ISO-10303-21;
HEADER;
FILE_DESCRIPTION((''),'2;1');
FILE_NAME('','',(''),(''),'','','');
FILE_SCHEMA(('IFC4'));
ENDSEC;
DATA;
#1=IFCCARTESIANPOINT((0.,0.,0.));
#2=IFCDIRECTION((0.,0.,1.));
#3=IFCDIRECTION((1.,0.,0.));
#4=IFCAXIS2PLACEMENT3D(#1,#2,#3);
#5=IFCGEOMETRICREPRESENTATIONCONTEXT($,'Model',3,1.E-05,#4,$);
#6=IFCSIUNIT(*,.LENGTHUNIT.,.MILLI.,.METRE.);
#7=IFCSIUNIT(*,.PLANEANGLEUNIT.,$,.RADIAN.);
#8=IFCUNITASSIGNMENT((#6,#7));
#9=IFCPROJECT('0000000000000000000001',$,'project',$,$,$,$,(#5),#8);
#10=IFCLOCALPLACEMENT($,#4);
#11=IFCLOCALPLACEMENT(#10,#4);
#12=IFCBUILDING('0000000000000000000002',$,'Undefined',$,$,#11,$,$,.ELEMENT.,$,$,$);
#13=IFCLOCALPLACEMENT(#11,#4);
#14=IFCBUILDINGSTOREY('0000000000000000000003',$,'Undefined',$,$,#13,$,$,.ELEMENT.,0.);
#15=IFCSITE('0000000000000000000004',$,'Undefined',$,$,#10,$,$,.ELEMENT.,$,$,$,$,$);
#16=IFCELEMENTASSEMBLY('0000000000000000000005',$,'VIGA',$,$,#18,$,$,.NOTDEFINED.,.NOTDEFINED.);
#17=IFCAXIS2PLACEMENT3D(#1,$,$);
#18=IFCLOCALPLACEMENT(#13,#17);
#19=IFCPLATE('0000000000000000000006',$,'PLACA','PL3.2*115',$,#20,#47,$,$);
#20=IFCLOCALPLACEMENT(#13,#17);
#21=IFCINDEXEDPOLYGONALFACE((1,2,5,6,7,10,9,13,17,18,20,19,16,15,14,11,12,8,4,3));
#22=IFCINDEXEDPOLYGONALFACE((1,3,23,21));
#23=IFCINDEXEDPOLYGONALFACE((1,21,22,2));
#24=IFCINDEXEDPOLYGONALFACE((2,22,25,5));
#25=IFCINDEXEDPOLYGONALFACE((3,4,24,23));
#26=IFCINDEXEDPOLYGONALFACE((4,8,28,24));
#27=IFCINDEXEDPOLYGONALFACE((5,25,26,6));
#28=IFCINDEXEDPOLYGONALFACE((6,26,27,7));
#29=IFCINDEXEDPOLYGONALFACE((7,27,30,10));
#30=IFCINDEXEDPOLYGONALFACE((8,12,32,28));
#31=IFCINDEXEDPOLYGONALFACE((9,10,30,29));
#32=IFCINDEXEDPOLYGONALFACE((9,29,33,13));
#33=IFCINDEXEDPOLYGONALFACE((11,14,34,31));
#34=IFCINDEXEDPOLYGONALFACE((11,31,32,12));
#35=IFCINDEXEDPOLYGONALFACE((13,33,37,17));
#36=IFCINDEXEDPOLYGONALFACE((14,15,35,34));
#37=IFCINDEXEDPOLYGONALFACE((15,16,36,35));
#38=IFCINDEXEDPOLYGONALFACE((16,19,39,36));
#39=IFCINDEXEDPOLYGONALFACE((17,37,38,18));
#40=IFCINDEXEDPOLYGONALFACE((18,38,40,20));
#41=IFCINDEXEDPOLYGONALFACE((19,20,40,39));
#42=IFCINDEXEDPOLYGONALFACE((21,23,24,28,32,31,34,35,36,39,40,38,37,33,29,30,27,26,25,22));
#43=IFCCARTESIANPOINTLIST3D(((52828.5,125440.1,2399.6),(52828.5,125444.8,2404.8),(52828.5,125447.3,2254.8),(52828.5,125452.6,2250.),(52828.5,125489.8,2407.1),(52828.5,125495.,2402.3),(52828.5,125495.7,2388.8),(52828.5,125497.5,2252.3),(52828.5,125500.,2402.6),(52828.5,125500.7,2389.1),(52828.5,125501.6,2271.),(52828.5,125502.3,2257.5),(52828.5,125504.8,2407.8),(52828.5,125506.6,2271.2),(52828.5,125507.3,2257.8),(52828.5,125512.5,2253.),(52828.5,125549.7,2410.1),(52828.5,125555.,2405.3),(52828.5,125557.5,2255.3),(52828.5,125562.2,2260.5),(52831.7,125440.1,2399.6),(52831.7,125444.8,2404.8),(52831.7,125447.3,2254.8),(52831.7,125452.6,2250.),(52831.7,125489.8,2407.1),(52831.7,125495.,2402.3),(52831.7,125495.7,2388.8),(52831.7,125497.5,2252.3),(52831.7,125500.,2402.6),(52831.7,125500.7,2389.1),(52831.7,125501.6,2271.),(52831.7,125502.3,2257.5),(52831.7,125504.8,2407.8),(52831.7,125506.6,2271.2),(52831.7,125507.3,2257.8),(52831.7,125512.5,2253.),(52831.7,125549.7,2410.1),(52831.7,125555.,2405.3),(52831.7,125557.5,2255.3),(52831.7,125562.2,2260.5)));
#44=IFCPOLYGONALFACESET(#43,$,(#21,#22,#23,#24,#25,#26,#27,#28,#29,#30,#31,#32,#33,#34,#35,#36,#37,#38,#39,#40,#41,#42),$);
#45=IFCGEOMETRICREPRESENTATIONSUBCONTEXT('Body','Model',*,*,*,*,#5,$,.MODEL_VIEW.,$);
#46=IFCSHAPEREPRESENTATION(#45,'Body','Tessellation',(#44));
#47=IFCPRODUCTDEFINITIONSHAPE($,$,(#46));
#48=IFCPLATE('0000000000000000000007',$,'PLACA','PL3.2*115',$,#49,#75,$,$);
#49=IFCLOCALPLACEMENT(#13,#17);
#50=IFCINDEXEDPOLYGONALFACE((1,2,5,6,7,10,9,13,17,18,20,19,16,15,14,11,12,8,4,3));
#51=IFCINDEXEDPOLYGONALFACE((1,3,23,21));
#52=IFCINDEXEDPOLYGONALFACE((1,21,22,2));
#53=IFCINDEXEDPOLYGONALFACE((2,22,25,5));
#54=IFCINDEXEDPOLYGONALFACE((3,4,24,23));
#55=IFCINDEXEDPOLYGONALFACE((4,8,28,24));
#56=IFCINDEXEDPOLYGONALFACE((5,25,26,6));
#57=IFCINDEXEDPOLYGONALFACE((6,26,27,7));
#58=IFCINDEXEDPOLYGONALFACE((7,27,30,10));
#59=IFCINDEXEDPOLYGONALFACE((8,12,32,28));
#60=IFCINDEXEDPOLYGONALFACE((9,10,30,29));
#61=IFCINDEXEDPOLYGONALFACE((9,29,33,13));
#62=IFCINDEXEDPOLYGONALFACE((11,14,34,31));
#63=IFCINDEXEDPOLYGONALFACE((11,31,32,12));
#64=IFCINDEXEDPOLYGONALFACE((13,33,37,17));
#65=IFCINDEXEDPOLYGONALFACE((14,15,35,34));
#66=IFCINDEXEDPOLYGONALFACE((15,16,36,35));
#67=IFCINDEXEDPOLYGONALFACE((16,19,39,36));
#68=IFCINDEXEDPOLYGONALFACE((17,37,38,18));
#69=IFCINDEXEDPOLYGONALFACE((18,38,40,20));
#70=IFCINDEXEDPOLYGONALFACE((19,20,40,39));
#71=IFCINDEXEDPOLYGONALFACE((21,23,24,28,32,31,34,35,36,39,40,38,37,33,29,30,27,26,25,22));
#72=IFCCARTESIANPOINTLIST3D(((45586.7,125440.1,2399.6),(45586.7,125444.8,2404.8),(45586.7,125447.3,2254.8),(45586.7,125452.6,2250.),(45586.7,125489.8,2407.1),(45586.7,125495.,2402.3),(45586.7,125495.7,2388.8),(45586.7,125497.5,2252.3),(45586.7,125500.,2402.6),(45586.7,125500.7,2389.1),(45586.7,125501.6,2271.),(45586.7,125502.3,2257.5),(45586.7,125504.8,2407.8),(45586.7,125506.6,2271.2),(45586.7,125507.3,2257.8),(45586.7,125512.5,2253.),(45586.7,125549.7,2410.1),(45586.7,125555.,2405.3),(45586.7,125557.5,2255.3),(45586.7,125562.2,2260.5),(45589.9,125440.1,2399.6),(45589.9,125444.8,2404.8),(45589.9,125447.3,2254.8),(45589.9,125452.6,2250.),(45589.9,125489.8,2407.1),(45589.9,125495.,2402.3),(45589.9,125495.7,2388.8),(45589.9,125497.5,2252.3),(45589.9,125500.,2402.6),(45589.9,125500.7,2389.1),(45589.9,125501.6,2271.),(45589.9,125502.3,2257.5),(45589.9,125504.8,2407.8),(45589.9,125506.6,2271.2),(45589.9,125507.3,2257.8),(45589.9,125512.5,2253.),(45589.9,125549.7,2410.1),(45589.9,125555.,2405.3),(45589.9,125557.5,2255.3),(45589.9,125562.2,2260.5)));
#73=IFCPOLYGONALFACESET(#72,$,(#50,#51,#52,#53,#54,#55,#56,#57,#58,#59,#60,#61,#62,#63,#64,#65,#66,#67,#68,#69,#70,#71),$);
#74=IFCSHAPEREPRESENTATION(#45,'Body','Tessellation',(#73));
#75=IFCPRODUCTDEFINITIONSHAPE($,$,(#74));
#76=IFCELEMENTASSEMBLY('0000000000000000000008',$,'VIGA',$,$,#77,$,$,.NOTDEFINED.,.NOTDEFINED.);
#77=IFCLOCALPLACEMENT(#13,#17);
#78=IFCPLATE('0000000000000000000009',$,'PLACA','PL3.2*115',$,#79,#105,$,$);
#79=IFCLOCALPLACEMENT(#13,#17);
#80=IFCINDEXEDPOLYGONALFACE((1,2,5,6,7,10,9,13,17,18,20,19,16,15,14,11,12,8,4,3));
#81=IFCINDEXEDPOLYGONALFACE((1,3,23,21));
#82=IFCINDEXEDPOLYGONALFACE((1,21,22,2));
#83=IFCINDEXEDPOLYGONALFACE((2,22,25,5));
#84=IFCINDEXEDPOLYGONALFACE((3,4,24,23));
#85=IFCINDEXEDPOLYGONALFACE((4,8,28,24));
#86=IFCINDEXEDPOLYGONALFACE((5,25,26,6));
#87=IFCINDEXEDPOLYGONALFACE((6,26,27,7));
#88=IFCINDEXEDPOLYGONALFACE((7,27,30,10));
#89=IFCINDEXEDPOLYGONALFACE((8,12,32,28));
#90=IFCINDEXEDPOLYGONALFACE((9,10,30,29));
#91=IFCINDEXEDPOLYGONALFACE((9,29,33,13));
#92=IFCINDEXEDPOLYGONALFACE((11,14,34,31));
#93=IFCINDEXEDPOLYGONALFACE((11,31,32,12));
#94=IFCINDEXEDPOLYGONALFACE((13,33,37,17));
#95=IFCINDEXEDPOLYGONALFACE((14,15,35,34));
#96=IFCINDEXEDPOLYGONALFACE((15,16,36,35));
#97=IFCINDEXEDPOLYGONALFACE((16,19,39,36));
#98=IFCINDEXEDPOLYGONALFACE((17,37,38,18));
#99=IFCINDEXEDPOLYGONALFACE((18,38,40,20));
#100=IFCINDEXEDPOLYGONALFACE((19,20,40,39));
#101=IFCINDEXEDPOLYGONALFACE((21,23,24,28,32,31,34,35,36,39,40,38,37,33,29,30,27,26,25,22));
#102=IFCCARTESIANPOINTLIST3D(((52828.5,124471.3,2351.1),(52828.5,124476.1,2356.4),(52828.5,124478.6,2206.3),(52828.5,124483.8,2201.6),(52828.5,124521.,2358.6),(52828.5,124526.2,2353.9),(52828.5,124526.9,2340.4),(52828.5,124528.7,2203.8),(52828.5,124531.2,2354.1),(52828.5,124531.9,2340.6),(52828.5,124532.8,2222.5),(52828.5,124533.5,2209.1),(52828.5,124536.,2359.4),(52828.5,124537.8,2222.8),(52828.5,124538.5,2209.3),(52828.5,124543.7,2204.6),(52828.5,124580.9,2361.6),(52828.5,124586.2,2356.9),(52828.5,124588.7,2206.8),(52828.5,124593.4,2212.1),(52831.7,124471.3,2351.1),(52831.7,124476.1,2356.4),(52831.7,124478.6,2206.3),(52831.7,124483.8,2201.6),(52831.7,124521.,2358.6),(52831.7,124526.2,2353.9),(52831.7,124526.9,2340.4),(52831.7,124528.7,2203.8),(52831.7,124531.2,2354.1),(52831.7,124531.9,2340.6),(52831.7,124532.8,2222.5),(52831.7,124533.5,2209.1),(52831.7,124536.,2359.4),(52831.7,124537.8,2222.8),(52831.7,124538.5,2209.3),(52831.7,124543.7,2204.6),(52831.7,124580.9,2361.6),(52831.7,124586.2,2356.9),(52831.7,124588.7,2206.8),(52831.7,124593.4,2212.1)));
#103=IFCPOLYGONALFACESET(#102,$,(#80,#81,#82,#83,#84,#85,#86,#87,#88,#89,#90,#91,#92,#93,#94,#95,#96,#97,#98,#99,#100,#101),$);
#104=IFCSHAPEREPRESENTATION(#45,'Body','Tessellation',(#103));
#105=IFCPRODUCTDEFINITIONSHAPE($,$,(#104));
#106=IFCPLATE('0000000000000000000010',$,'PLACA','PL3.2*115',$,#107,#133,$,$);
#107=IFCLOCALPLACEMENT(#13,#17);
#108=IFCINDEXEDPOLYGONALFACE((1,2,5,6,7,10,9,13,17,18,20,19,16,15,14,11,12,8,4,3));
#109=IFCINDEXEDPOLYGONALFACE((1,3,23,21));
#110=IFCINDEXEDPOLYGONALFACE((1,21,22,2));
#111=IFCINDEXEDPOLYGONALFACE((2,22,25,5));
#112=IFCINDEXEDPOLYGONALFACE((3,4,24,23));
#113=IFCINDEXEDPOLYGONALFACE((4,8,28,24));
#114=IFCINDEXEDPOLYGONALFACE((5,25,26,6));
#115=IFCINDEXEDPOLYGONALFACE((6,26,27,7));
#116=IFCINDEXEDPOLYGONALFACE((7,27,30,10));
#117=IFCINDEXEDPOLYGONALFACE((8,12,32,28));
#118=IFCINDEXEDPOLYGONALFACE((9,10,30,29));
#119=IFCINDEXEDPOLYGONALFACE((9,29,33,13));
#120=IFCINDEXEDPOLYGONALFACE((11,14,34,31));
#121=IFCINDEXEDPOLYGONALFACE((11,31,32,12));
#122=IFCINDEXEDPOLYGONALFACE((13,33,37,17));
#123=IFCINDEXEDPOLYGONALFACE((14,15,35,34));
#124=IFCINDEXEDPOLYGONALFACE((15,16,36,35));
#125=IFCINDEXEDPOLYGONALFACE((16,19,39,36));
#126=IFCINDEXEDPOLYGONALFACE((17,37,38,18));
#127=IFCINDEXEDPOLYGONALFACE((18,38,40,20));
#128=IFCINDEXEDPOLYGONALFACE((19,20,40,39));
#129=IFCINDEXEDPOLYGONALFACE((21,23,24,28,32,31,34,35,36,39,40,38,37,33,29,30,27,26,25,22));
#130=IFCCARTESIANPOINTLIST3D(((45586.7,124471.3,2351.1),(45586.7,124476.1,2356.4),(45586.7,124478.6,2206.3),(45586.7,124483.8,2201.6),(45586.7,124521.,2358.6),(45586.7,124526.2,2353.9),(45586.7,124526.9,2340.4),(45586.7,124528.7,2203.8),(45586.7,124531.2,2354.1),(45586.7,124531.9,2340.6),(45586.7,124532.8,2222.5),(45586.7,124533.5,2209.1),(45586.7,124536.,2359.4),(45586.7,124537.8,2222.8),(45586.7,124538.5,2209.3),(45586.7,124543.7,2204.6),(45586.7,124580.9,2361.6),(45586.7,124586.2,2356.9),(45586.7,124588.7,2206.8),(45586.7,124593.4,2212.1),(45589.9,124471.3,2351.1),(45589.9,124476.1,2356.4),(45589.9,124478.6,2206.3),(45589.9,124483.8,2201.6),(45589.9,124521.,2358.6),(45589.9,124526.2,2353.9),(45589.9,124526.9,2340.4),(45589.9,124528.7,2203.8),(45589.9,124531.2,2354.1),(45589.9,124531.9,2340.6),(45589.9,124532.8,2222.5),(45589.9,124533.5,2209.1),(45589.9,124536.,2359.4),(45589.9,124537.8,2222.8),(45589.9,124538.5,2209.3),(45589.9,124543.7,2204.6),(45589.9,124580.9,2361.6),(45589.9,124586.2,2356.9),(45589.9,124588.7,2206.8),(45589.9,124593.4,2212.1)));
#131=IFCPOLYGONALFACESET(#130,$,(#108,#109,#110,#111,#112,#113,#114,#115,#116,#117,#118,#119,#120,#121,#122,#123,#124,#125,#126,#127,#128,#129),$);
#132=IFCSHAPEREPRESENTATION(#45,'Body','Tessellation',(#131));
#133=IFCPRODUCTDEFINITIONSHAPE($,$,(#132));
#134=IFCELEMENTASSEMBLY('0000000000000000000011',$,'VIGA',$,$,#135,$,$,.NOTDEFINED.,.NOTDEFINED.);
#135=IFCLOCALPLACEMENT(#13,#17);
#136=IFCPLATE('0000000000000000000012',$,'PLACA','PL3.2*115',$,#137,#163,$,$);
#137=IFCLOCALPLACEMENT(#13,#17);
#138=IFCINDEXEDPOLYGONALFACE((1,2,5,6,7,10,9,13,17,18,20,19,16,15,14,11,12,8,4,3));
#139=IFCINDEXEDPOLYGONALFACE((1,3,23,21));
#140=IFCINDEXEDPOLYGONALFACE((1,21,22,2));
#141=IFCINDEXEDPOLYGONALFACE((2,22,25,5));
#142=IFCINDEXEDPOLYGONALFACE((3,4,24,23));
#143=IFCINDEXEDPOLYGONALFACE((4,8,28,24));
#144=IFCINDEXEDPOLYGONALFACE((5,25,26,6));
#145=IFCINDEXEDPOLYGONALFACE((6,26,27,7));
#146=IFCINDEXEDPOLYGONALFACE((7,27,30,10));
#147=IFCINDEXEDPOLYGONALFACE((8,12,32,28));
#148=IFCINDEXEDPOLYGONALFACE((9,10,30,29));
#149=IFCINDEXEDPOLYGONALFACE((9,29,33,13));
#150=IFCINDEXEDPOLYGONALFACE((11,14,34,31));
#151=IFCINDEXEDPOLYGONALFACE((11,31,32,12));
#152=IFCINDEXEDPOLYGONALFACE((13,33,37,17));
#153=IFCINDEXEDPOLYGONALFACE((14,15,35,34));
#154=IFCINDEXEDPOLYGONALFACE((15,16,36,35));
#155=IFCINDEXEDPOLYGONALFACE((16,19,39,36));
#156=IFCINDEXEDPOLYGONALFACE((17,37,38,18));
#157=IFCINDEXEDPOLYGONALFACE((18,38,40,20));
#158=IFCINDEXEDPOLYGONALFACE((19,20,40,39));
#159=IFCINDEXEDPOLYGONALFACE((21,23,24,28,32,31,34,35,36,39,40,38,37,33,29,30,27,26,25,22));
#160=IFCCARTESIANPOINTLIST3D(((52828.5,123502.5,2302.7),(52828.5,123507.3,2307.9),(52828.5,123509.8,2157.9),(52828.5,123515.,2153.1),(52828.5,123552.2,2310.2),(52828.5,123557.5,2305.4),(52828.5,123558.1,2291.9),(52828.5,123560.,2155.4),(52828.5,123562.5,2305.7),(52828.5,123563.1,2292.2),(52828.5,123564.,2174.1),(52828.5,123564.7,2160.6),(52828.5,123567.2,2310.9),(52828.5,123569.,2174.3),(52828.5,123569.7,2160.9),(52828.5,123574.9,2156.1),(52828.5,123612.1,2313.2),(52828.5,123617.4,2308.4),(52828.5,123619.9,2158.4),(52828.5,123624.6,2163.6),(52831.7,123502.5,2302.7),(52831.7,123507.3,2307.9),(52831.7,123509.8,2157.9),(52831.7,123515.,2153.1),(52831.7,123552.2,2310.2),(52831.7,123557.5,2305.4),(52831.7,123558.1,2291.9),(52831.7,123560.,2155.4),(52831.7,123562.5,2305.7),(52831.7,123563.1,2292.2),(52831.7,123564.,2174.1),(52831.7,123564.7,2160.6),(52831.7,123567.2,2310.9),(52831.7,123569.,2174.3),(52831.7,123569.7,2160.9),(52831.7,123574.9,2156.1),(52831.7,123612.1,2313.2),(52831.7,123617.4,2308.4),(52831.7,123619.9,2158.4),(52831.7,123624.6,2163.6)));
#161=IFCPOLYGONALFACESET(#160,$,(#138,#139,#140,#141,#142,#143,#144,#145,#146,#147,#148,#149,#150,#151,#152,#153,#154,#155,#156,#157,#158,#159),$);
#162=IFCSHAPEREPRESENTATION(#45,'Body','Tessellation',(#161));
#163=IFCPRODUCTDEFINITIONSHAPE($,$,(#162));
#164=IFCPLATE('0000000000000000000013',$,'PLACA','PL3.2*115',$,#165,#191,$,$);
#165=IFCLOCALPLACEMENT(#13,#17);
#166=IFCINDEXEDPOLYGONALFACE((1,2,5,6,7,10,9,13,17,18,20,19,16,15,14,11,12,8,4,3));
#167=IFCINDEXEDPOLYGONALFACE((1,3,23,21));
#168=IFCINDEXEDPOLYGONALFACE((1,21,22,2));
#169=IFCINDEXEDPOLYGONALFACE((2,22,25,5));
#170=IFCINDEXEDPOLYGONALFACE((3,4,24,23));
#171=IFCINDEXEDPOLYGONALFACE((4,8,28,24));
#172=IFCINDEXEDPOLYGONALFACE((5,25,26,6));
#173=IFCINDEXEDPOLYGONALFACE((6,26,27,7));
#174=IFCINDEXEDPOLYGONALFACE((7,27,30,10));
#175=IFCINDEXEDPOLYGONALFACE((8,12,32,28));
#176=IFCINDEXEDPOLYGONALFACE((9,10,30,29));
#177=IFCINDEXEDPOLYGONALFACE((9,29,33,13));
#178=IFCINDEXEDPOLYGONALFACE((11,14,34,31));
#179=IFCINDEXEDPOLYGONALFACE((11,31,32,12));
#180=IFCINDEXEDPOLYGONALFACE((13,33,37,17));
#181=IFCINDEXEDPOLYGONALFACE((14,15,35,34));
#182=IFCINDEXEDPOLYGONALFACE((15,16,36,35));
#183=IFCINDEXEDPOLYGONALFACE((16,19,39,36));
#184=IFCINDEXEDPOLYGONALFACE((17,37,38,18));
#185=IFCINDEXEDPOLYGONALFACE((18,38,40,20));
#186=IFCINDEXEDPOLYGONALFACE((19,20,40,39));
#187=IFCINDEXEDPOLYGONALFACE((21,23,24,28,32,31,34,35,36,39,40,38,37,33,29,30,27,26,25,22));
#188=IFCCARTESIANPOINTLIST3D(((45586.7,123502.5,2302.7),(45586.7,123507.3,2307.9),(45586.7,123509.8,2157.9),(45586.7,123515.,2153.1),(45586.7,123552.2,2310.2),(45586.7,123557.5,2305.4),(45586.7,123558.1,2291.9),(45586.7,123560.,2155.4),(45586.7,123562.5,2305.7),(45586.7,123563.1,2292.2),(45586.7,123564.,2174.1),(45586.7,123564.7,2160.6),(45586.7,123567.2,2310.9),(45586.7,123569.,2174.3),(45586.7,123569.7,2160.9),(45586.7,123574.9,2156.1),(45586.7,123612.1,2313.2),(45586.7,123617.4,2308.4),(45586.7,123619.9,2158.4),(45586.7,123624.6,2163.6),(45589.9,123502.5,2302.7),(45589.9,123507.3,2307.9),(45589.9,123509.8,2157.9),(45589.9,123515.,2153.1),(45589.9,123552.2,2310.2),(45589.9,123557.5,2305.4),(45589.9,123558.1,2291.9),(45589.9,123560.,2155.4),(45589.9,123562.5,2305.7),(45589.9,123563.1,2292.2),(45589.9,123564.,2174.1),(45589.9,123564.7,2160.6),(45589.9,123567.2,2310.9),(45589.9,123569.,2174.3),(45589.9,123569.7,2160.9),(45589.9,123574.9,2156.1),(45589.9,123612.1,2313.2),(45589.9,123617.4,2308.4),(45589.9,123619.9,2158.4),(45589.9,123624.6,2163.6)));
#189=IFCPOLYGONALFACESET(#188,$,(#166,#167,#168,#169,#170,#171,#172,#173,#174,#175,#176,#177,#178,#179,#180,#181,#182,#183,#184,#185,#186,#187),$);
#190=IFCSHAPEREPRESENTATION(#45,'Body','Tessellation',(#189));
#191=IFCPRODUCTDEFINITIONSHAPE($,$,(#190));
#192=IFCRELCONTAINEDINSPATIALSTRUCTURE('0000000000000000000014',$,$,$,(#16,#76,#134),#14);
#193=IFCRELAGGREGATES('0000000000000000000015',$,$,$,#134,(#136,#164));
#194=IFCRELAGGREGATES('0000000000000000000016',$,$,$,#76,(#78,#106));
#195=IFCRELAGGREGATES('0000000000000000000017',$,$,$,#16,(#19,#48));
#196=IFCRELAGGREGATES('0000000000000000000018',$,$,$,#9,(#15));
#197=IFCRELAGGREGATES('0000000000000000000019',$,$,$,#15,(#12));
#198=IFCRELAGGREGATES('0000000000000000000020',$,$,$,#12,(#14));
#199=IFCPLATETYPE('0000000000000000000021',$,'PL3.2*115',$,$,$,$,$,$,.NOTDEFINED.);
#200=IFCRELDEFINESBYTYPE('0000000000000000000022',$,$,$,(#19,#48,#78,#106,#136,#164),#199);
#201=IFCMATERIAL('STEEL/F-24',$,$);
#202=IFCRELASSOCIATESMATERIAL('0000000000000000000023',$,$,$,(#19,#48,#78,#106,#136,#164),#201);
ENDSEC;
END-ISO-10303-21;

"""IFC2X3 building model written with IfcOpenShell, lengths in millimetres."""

from ifc_helpers import new_model, si_unit, frame, origin_with_axes, place, context, subcontext, project, spatial, polyline, outline, extrude, material, type_object, element, aggregate, save


model = new_model("IFC2X3")

# Units and contexts
model_context = context("Model", 3, precision=1e-05, world=origin_with_axes())
body_context = subcontext(model_context, "Body", "Model", "MODEL_VIEW")
ifc_project = project(units=[si_unit("LENGTHUNIT", "METRE", prefix="MILLI"), si_unit("PLANEANGLEUNIT", "RADIAN")], contexts=[model_context])

# Site, building, storey
site_placement = place(None, origin_with_axes())
site = spatial("IfcSite", under=ifc_project, at=site_placement, Name="Undefined", CompositionType="ELEMENT")
building_placement = place(site_placement, origin_with_axes())
building = spatial("IfcBuilding", under=site, at=building_placement, Name="Undefined", CompositionType="ELEMENT")
storey_placement = place(building_placement, origin_with_axes())
storey = spatial("IfcBuildingStorey", under=building, at=storey_placement, Name="Undefined", CompositionType="ELEMENT", Elevation=0.0)

# Element assemblies, plates
ifc_material_1 = material(Name="STEEL/F-24")
plate_type_1 = type_object("IfcPlateType", Name="PL3.2*115", PredefinedType="NOTDEFINED")
assembly_1_placement = place(storey_placement, origin_with_axes())
assembly_1 = element("IfcElementAssembly", 1, at=assembly_1_placement, inside=storey, Name="VIGA", AssemblyPlace="NOTDEFINED", PredefinedType="NOTDEFINED")
plate_1_placement = place(assembly_1_placement, frame((52830.1, 125439.9, 2404.6), z_axis=(-1.0, 0.0, 0.0), x_axis=(0.0, 0.998752, 0.04995)))
plate_1 = element("IfcPlate", 2, at=plate_1_placement, type_object=plate_type_1, material=ifc_material_1, Name="PLACA", Description="PL3.2*115", context=body_context, shape_type="SweptSolid", body=[
    extrude(outline(polyline([(0.0, 5.0), (5.0, 0.0), (50.0, 0.0), (55.0, 5.0), (55.0, 18.5), (60.0, 18.5), (60.0, 5.0), (65.0, 0.0), (110.0, 0.0), (115.0, 5.0), (115.0, 150.0), (110.0, 155.0), (65.0, 155.0), (60.0, 150.0), (60.0, 136.5), (55.0, 136.5), (55.0, 150.0), (50.0, 155.0), (5.0, 155.0), (0.0, 150.0), (0.0, 5.0)])), frame((0.0, 0.0, -1.6), z_axis=(0.0, 0.0, 1.0), x_axis=(1.0, 0.0, 0.0)), (0.0, 0.0, 1.0), 3.2),
])
plate_2_placement = place(assembly_1_placement, frame((45588.3, 125439.9, 2404.6), z_axis=(-1.0, 0.0, 0.0), x_axis=(0.0, 0.998752, 0.04995)))
plate_2 = element("IfcPlate", 3, at=plate_2_placement, type_object=plate_type_1, material=ifc_material_1, Name="PLACA", Description="PL3.2*115", context=body_context, shape_type="SweptSolid", body=[
    extrude(outline(polyline([(0.0, 5.0), (5.0, 0.0), (50.0, 0.0), (55.0, 5.0), (55.0, 18.5), (60.0, 18.5), (60.0, 5.0), (65.0, 0.0), (110.0, 0.0), (115.0, 5.0), (115.0, 150.0), (110.0, 155.0), (65.0, 155.0), (60.0, 150.0), (60.0, 136.5), (55.0, 136.5), (55.0, 150.0), (50.0, 155.0), (5.0, 155.0), (0.0, 150.0), (0.0, 5.0)])), frame((0.0, 0.0, -1.6), z_axis=(0.0, 0.0, 1.0), x_axis=(1.0, 0.0, 0.0)), (0.0, 0.0, 1.0), 3.2),
])
assembly_2_placement = place(storey_placement, origin_with_axes())
assembly_2 = element("IfcElementAssembly", 4, at=assembly_2_placement, inside=storey, Name="VIGA", AssemblyPlace="NOTDEFINED", PredefinedType="NOTDEFINED")
plate_3_placement = place(assembly_2_placement, frame((52830.1, 124471.1, 2356.1), z_axis=(-1.0, 0.0, 0.0), x_axis=(0.0, 0.998752, 0.04995)))
plate_3 = element("IfcPlate", 5, at=plate_3_placement, type_object=plate_type_1, material=ifc_material_1, Name="PLACA", Description="PL3.2*115", context=body_context, shape_type="SweptSolid", body=[
    extrude(outline(polyline([(0.0, 5.0), (5.0, 0.0), (50.0, 0.0), (55.0, 5.0), (55.0, 18.5), (60.0, 18.5), (60.0, 5.0), (65.0, 0.0), (110.0, 0.0), (115.0, 5.0), (115.0, 150.0), (110.0, 155.0), (65.0, 155.0), (60.0, 150.0), (60.0, 136.5), (55.0, 136.5), (55.0, 150.0), (50.0, 155.0), (5.0, 155.0), (0.0, 150.0), (0.0, 5.0)])), frame((0.0, 0.0, -1.6), z_axis=(0.0, 0.0, 1.0), x_axis=(1.0, 0.0, 0.0)), (0.0, 0.0, 1.0), 3.2),
])
plate_4_placement = place(assembly_2_placement, frame((45588.3, 124471.1, 2356.1), z_axis=(-1.0, 0.0, 0.0), x_axis=(0.0, 0.998752, 0.04995)))
plate_4 = element("IfcPlate", 6, at=plate_4_placement, type_object=plate_type_1, material=ifc_material_1, Name="PLACA", Description="PL3.2*115", context=body_context, shape_type="SweptSolid", body=[
    extrude(outline(polyline([(0.0, 5.0), (5.0, 0.0), (50.0, 0.0), (55.0, 5.0), (55.0, 18.5), (60.0, 18.5), (60.0, 5.0), (65.0, 0.0), (110.0, 0.0), (115.0, 5.0), (115.0, 150.0), (110.0, 155.0), (65.0, 155.0), (60.0, 150.0), (60.0, 136.5), (55.0, 136.5), (55.0, 150.0), (50.0, 155.0), (5.0, 155.0), (0.0, 150.0), (0.0, 5.0)])), frame((0.0, 0.0, -1.6), z_axis=(0.0, 0.0, 1.0), x_axis=(1.0, 0.0, 0.0)), (0.0, 0.0, 1.0), 3.2),
])
assembly_3_placement = place(storey_placement, origin_with_axes())
assembly_3 = element("IfcElementAssembly", 7, at=assembly_3_placement, inside=storey, Name="VIGA", AssemblyPlace="NOTDEFINED", PredefinedType="NOTDEFINED")
plate_5_placement = place(assembly_3_placement, frame((52830.1, 123502.3, 2307.7), z_axis=(-1.0, 0.0, 0.0), x_axis=(0.0, 0.998752, 0.04995)))
plate_5 = element("IfcPlate", 8, at=plate_5_placement, type_object=plate_type_1, material=ifc_material_1, Name="PLACA", Description="PL3.2*115", context=body_context, shape_type="SweptSolid", body=[
    extrude(outline(polyline([(0.0, 5.0), (5.0, 0.0), (50.0, 0.0), (55.0, 5.0), (55.0, 18.5), (60.0, 18.5), (60.0, 5.0), (65.0, 0.0), (110.0, 0.0), (115.0, 5.0), (115.0, 150.0), (110.0, 155.0), (65.0, 155.0), (60.0, 150.0), (60.0, 136.5), (55.0, 136.5), (55.0, 150.0), (50.0, 155.0), (5.0, 155.0), (0.0, 150.0), (0.0, 5.0)])), frame((0.0, 0.0, -1.6), z_axis=(0.0, 0.0, 1.0), x_axis=(1.0, 0.0, 0.0)), (0.0, 0.0, 1.0), 3.2),
])
plate_6_placement = place(assembly_3_placement, frame((45588.3, 123502.3, 2307.7), z_axis=(-1.0, 0.0, 0.0), x_axis=(0.0, 0.998752, 0.04995)))
plate_6 = element("IfcPlate", 9, at=plate_6_placement, type_object=plate_type_1, material=ifc_material_1, Name="PLACA", Description="PL3.2*115", context=body_context, shape_type="SweptSolid", body=[
    extrude(outline(polyline([(0.0, 5.0), (5.0, 0.0), (50.0, 0.0), (55.0, 5.0), (55.0, 18.5), (60.0, 18.5), (60.0, 5.0), (65.0, 0.0), (110.0, 0.0), (115.0, 5.0), (115.0, 150.0), (110.0, 155.0), (65.0, 155.0), (60.0, 150.0), (60.0, 136.5), (55.0, 136.5), (55.0, 150.0), (50.0, 155.0), (5.0, 155.0), (0.0, 150.0), (0.0, 5.0)])), frame((0.0, 0.0, -1.6), z_axis=(0.0, 0.0, 1.0), x_axis=(1.0, 0.0, 0.0)), (0.0, 0.0, 1.0), 3.2),
])

aggregate(assembly_3, [plate_5, plate_6])
aggregate(assembly_2, [plate_3, plate_4])
aggregate(assembly_1, [plate_1, plate_2])

save(model, "model.ifc")
